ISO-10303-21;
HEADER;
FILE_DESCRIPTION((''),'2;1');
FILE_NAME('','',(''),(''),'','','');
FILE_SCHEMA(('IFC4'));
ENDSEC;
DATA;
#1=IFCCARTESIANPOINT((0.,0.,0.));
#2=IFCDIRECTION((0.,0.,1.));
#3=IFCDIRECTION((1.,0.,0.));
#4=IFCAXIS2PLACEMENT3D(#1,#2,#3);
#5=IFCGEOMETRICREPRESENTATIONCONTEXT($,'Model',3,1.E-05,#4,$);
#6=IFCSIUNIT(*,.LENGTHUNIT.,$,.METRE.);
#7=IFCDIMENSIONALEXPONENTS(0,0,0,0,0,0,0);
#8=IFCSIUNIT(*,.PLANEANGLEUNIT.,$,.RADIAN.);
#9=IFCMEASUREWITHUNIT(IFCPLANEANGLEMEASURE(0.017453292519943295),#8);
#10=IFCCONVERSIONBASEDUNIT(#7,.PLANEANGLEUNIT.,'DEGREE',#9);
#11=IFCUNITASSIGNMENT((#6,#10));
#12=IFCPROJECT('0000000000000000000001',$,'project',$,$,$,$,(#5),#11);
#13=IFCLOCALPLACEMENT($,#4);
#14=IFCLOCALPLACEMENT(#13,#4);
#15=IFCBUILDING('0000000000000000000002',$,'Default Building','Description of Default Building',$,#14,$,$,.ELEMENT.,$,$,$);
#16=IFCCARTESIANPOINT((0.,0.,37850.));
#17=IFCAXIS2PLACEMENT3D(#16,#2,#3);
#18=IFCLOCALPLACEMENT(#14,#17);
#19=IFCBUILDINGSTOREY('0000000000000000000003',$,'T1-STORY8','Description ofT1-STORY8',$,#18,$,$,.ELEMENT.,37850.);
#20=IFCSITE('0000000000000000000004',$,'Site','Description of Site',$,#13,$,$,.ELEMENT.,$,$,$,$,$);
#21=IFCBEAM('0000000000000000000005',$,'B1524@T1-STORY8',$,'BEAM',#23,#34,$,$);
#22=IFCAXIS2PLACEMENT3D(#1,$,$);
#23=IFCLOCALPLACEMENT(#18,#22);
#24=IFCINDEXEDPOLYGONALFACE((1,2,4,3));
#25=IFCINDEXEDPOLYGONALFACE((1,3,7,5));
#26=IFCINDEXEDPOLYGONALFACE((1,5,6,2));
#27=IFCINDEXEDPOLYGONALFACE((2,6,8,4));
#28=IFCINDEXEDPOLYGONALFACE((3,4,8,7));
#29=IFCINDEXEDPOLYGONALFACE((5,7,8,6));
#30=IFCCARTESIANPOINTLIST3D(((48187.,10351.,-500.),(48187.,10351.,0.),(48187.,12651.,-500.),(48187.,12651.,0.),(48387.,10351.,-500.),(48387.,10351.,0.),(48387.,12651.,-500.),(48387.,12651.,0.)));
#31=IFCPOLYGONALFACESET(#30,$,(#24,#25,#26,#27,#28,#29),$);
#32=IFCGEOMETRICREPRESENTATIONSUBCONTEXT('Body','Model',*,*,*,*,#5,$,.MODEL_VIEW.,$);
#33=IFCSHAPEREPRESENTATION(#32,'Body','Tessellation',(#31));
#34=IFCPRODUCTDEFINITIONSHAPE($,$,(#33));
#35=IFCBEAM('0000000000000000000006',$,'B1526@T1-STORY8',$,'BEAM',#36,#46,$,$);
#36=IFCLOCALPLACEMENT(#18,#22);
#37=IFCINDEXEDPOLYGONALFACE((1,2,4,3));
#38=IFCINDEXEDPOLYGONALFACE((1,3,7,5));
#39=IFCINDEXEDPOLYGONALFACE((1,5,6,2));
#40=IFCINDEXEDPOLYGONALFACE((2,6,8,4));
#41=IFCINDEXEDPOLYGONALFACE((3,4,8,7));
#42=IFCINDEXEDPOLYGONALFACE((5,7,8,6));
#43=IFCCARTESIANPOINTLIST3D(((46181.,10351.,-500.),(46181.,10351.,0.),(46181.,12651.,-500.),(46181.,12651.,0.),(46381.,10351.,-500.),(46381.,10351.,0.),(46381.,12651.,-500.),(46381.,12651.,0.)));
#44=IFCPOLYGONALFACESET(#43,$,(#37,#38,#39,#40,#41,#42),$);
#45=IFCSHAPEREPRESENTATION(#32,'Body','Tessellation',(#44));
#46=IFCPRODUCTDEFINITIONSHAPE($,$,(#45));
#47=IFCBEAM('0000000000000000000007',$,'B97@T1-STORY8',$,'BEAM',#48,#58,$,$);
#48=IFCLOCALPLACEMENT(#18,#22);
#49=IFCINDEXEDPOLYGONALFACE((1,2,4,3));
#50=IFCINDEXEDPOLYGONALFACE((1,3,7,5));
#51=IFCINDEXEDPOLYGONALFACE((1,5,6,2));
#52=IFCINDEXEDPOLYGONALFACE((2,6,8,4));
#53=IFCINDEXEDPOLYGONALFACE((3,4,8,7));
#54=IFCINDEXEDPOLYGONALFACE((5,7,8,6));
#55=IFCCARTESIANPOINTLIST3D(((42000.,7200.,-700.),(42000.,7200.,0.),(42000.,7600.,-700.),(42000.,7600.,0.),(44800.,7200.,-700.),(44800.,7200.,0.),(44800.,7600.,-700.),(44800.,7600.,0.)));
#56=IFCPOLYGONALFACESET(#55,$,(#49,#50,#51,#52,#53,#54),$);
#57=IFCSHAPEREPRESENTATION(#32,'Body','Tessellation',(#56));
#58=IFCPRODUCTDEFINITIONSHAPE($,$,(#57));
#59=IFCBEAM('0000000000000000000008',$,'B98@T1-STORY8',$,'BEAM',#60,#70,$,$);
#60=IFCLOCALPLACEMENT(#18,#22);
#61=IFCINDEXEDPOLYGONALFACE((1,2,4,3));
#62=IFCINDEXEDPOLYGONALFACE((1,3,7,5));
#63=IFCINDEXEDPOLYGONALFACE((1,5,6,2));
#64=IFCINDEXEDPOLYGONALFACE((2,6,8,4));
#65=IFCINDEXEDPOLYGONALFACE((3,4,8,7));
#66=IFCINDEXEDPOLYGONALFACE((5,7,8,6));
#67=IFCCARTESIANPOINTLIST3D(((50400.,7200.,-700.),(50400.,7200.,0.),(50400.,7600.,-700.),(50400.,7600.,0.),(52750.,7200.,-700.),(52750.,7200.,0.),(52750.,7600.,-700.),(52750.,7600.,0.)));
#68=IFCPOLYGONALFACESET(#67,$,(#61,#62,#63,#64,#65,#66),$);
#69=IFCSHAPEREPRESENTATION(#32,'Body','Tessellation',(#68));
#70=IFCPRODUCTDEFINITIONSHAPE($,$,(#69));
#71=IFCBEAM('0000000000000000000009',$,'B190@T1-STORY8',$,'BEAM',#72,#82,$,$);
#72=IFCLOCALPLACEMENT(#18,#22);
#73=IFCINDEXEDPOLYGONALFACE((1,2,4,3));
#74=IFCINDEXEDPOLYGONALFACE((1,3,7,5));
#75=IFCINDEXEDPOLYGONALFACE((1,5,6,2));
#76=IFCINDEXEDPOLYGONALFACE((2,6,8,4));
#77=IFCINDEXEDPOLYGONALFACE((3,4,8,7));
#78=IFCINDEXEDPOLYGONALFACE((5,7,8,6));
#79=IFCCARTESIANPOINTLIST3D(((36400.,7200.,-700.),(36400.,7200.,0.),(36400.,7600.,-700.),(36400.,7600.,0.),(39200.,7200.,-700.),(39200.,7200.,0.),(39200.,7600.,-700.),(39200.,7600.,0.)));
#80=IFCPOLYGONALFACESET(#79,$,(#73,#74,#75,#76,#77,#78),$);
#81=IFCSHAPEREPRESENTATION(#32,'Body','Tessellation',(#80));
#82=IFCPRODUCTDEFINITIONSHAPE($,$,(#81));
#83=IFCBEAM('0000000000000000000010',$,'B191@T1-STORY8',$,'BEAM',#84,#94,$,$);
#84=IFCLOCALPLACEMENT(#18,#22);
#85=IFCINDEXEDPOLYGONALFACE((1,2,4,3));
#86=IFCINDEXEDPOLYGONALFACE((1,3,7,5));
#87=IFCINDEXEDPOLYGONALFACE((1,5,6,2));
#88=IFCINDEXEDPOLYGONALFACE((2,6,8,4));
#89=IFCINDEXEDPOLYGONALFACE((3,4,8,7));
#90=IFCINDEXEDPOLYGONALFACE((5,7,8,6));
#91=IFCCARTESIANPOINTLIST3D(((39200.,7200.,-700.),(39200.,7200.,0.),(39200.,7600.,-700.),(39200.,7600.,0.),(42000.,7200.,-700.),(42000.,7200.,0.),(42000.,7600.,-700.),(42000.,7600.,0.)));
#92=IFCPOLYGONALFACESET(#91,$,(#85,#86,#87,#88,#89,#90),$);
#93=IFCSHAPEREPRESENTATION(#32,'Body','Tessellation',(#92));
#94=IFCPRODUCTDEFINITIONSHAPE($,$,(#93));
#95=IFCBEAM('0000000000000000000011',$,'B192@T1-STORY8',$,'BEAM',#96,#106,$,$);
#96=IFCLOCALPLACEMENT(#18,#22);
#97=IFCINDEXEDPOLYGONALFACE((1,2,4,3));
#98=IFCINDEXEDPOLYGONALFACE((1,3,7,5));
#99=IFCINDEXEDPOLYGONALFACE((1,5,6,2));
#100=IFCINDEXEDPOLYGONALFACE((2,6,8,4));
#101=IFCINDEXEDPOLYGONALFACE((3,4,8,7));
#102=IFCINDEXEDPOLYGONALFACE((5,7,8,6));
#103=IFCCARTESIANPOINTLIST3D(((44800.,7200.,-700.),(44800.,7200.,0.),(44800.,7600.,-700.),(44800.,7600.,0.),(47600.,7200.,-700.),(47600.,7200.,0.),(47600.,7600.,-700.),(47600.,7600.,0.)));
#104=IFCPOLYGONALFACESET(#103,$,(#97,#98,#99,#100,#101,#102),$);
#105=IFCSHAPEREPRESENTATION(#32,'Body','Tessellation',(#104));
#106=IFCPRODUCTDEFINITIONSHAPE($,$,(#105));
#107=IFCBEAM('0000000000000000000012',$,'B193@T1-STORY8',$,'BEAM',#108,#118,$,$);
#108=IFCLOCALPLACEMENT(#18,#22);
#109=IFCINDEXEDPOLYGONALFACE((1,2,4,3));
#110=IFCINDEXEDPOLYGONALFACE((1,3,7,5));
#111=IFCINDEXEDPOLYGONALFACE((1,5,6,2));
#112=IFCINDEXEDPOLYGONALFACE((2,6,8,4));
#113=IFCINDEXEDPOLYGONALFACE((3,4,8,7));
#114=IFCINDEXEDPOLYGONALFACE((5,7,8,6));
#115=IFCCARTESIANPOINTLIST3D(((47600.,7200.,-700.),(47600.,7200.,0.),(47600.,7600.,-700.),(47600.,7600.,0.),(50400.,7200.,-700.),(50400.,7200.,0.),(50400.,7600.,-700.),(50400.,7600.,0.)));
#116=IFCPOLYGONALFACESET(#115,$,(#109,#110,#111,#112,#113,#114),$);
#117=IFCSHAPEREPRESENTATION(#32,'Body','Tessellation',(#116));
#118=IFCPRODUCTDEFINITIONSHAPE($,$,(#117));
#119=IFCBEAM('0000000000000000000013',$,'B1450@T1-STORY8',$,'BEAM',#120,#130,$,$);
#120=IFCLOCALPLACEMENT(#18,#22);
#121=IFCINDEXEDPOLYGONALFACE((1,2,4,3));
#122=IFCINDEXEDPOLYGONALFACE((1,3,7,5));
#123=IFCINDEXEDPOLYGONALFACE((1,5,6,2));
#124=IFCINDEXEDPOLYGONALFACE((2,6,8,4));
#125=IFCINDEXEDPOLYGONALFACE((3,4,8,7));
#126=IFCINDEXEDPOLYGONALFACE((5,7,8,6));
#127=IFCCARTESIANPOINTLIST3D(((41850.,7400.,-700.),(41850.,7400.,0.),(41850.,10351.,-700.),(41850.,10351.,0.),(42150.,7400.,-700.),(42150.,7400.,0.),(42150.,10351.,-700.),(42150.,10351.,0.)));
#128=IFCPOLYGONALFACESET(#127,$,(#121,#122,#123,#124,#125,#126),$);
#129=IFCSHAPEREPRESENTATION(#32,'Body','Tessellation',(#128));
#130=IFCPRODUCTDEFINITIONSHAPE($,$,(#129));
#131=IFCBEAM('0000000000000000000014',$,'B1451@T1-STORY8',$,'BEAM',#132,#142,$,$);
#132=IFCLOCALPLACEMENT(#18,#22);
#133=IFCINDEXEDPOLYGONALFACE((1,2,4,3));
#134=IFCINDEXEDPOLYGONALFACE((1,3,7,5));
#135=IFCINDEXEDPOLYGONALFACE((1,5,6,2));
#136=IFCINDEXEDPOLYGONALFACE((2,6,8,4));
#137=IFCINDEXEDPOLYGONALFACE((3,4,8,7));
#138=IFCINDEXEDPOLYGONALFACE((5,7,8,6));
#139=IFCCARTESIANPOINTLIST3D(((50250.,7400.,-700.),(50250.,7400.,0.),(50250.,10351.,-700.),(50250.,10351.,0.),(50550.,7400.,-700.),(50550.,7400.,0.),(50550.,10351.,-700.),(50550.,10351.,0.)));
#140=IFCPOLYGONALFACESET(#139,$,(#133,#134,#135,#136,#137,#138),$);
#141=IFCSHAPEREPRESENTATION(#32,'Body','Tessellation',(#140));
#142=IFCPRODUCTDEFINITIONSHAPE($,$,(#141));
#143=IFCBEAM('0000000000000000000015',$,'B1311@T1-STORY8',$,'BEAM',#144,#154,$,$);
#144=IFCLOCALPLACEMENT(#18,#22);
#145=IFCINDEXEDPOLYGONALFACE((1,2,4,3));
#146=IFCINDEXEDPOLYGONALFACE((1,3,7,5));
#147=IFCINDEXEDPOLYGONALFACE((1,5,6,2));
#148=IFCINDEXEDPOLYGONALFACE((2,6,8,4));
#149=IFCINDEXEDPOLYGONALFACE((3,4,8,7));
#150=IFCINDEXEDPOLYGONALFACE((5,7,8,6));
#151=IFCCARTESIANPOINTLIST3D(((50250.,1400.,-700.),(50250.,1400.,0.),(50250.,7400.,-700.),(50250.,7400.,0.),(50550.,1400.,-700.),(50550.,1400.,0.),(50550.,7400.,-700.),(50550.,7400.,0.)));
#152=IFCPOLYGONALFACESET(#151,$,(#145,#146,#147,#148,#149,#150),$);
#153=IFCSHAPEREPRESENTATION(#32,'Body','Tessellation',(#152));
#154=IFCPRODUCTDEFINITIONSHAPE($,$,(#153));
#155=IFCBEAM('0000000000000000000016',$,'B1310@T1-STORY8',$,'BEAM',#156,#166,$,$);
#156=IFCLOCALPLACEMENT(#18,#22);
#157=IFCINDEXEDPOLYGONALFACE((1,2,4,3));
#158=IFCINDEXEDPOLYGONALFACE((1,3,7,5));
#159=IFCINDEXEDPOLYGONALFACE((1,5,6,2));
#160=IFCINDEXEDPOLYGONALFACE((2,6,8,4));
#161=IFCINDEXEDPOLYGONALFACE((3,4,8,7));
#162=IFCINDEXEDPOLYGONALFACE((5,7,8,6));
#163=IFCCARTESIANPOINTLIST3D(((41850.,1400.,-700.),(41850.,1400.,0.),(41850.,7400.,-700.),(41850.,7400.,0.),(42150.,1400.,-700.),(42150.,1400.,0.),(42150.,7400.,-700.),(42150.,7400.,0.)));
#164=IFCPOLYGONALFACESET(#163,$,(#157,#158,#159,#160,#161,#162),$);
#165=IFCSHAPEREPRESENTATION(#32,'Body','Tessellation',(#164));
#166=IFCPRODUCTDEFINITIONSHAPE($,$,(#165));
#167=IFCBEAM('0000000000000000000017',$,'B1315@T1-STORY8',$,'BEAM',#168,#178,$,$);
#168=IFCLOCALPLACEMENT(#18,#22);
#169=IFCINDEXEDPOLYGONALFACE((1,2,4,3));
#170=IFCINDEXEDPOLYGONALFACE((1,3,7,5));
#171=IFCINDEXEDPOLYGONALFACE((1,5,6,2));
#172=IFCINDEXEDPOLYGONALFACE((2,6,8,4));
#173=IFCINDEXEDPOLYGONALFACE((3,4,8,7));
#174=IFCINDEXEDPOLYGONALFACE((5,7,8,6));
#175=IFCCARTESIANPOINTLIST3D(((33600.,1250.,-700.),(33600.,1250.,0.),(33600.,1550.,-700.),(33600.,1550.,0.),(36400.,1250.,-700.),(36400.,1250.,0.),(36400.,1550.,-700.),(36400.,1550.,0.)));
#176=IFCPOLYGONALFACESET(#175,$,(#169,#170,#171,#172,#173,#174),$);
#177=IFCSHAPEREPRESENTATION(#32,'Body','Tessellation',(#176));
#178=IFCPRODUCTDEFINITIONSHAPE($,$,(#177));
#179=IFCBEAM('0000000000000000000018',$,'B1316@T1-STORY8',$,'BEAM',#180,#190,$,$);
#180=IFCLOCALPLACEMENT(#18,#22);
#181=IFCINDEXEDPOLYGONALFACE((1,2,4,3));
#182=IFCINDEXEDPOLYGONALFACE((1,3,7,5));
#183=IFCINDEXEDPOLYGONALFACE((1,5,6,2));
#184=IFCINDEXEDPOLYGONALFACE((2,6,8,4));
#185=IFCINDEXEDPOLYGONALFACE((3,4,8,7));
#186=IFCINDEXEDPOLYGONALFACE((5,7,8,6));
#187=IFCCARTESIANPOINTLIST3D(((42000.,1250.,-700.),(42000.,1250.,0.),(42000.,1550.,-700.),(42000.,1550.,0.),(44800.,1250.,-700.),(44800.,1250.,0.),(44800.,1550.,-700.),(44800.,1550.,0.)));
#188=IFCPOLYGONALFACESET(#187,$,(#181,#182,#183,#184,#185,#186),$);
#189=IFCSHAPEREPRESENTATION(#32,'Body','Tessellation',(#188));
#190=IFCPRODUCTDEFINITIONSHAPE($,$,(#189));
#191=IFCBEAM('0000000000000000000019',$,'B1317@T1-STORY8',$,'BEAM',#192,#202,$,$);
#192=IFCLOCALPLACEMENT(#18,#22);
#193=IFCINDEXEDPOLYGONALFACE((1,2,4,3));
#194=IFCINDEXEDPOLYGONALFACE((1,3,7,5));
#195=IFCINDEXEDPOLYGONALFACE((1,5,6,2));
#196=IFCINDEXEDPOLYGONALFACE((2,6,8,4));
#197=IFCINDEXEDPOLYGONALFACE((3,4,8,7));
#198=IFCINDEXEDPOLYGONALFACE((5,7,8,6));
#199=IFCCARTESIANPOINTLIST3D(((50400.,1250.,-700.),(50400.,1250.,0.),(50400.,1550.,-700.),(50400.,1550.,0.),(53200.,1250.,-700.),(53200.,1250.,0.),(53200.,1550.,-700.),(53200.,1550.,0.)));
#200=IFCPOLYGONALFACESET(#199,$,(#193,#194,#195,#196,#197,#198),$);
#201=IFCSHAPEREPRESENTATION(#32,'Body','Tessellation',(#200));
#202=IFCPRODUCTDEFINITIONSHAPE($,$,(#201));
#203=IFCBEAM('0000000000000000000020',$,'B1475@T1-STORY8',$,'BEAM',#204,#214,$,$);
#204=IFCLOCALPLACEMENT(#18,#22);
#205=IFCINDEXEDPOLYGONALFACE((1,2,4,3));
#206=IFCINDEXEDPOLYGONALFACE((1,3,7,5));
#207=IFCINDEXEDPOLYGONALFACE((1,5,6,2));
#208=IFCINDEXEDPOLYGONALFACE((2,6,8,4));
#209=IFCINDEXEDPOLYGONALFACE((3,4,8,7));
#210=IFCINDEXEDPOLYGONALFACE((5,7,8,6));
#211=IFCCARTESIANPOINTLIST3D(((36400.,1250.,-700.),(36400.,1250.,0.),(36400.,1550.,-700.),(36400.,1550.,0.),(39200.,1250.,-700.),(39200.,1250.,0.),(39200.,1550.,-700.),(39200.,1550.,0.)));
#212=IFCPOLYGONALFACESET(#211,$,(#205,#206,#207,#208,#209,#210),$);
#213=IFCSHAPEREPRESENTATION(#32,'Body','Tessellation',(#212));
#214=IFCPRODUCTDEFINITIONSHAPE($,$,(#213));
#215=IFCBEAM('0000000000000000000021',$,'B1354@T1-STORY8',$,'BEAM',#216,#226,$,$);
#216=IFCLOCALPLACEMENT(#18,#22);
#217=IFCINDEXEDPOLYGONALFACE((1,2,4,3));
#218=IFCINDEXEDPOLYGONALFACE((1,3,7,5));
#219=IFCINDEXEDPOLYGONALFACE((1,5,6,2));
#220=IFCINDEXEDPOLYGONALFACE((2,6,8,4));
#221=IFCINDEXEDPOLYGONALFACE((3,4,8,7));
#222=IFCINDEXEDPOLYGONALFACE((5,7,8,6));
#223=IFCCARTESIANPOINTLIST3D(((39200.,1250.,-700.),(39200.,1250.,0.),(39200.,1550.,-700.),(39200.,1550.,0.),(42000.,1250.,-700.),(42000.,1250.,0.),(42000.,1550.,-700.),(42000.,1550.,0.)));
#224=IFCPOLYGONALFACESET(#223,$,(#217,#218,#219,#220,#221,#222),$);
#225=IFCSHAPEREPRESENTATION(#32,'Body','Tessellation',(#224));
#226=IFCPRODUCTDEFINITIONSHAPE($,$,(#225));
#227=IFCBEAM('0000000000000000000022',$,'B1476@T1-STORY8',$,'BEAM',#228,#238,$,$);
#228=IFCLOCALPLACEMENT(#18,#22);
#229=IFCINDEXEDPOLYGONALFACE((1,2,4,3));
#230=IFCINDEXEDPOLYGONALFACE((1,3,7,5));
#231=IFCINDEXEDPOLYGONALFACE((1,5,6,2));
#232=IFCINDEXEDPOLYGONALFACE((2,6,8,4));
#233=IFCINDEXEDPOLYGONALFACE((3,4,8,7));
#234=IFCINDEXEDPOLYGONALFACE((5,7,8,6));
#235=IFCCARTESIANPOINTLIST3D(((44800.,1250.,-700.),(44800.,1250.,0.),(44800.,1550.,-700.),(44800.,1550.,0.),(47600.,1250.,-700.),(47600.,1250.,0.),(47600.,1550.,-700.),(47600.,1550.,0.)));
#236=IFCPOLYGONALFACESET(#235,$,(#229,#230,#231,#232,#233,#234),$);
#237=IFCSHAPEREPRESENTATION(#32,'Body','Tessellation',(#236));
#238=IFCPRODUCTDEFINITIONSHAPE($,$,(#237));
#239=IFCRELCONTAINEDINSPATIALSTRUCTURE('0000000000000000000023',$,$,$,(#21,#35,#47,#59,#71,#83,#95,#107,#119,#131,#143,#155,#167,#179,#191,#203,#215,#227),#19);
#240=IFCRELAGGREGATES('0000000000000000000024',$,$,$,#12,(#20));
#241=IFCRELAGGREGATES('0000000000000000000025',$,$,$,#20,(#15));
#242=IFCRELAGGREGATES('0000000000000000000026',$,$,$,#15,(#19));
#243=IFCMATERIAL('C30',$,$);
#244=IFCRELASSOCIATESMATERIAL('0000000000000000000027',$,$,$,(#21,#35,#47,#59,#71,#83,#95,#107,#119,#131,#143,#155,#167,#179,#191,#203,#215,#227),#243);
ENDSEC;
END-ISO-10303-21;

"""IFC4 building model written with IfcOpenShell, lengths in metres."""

from ifc_helpers import new_model, entity, si_unit, converted_unit, frame, origin_with_axes, place, context, subcontext, project, spatial, rectangle, extrude, material, element, save


model = new_model("IFC4")

# Units and contexts
model_context = context("Model", 3, precision=1e-05, world=origin_with_axes())
body_context = subcontext(model_context, "Body", "Model", "MODEL_VIEW")
ifc_project = project(units=[si_unit("LENGTHUNIT", "METRE"), converted_unit("PLANEANGLEUNIT", "DEGREE", entity("IfcPlaneAngleMeasure", 0.017453292519943295), si_unit("PLANEANGLEUNIT", "RADIAN"), dimensions=[0, 0, 0, 0, 0, 0, 0])], contexts=[model_context])

# Site, building, storey
site_placement = place(None, origin_with_axes())
site = spatial("IfcSite", under=ifc_project, at=site_placement, Name="Site", Description="Description of Site", CompositionType="ELEMENT")
building_placement = place(site_placement, origin_with_axes())
building = spatial("IfcBuilding", under=site, at=building_placement, Name="Default Building", Description="Description of Default Building", CompositionType="ELEMENT")
storey_placement = place(building_placement, frame((0.0, 0.0, 37850.0), z_axis=(0.0, 0.0, 1.0), x_axis=(1.0, 0.0, 0.0)))
storey = spatial("IfcBuildingStorey", under=building, at=storey_placement, Name="T1-STORY8", Description="Description ofT1-STORY8", CompositionType="ELEMENT", Elevation=37850.0)

# Beams
ifc_material_1 = material(Name="C30")
for number, where, z_axis, x_axis, name in (
    (1, (48287.0, 10351.0, -250.0), (0.0, 1.0, 0.0), (-1.0, 0.0, 0.0), "B1524@T1-STORY8"),
    (2, (46281.0, 10351.0, -250.0), (0.0, 1.0, 0.0), (-1.0, 0.0, 0.0), "B1526@T1-STORY8"),
):
    element("IfcBeam", number, at=place(storey_placement, frame(where, z_axis=z_axis, x_axis=x_axis)), inside=storey, material=ifc_material_1, Name=name, ObjectType="BEAM", context=body_context, shape_type="SweptSolid", body=[
        extrude(rectangle(XDim=200.0, YDim=500.0), origin_with_axes(), (0.0, 0.0, 1.0), 2300.0),
    ])
beam_1_placement = place(storey_placement, frame((42000.0, 7400.0, -350.0), z_axis=(1.0, 0.0, 0.0), x_axis=(0.0, 1.0, 0.0)))
element("IfcBeam", 3, at=beam_1_placement, inside=storey, material=ifc_material_1, Name="B97@T1-STORY8", ObjectType="BEAM", context=body_context, shape_type="SweptSolid", body=[
    extrude(rectangle(XDim=400.0, YDim=700.0), origin_with_axes(), (0.0, 0.0, 1.0), 2800.0),
])
beam_2_placement = place(storey_placement, frame((50400.0, 7400.0, -350.0), z_axis=(1.0, 0.0, 0.0), x_axis=(0.0, 1.0, 0.0)))
element("IfcBeam", 4, at=beam_2_placement, inside=storey, material=ifc_material_1, Name="B98@T1-STORY8", ObjectType="BEAM", context=body_context, shape_type="SweptSolid", body=[
    extrude(rectangle(XDim=400.0, YDim=700.0), origin_with_axes(), (0.0, 0.0, 1.0), 2350.0),
])
for number, where, z_axis, x_axis, name in (
    (5, (36400.0, 7400.0, -350.0), (1.0, 0.0, 0.0), (0.0, 1.0, 0.0), "B190@T1-STORY8"),
    (6, (39200.0, 7400.0, -350.0), (1.0, 0.0, 0.0), (0.0, 1.0, 0.0), "B191@T1-STORY8"),
    (7, (44800.0, 7400.0, -350.0), (1.0, 0.0, 0.0), (0.0, 1.0, 0.0), "B192@T1-STORY8"),
    (8, (47600.0, 7400.0, -350.0), (1.0, 0.0, 0.0), (0.0, 1.0, 0.0), "B193@T1-STORY8"),
):
    element("IfcBeam", number, at=place(storey_placement, frame(where, z_axis=z_axis, x_axis=x_axis)), inside=storey, material=ifc_material_1, Name=name, ObjectType="BEAM", context=body_context, shape_type="SweptSolid", body=[
        extrude(rectangle(XDim=400.0, YDim=700.0), origin_with_axes(), (0.0, 0.0, 1.0), 2800.0),
    ])
for number, where, z_axis, x_axis, name in (
    (9, (42000.0, 7400.0, -350.0), (0.0, 1.0, 0.0), (-1.0, 0.0, 0.0), "B1450@T1-STORY8"),
    (10, (50400.0, 7400.0, -350.0), (0.0, 1.0, 0.0), (-1.0, 0.0, 0.0), "B1451@T1-STORY8"),
):
    element("IfcBeam", number, at=place(storey_placement, frame(where, z_axis=z_axis, x_axis=x_axis)), inside=storey, material=ifc_material_1, Name=name, ObjectType="BEAM", context=body_context, shape_type="SweptSolid", body=[
        extrude(rectangle(XDim=300.0, YDim=700.0), origin_with_axes(), (0.0, 0.0, 1.0), 2951.0),
    ])
for number, where, z_axis, x_axis, name in (
    (11, (50400.0, 1400.0, -350.0), (0.0, 1.0, 0.0), (-1.0, 0.0, 0.0), "B1311@T1-STORY8"),
    (12, (42000.0, 1400.0, -350.0), (0.0, 1.0, 0.0), (-1.0, 0.0, 0.0), "B1310@T1-STORY8"),
):
    element("IfcBeam", number, at=place(storey_placement, frame(where, z_axis=z_axis, x_axis=x_axis)), inside=storey, material=ifc_material_1, Name=name, ObjectType="BEAM", context=body_context, shape_type="SweptSolid", body=[
        extrude(rectangle(XDim=300.0, YDim=700.0), origin_with_axes(), (0.0, 0.0, 1.0), 6000.0),
    ])
for number, where, z_axis, x_axis, name in (
    (13, (33600.0, 1400.0, -350.0), (1.0, 0.0, 0.0), (0.0, 1.0, 0.0), "B1315@T1-STORY8"),
    (14, (42000.0, 1400.0, -350.0), (1.0, 0.0, 0.0), (0.0, 1.0, 0.0), "B1316@T1-STORY8"),
    (15, (50400.0, 1400.0, -350.0), (1.0, 0.0, 0.0), (0.0, 1.0, 0.0), "B1317@T1-STORY8"),
    (16, (36400.0, 1400.0, -350.0), (1.0, 0.0, 0.0), (0.0, 1.0, 0.0), "B1475@T1-STORY8"),
    (17, (39200.0, 1400.0, -350.0), (1.0, 0.0, 0.0), (0.0, 1.0, 0.0), "B1354@T1-STORY8"),
    (18, (44800.0, 1400.0, -350.0), (1.0, 0.0, 0.0), (0.0, 1.0, 0.0), "B1476@T1-STORY8"),
):
    element("IfcBeam", number, at=place(storey_placement, frame(where, z_axis=z_axis, x_axis=x_axis)), inside=storey, material=ifc_material_1, Name=name, ObjectType="BEAM", context=body_context, shape_type="SweptSolid", body=[
        extrude(rectangle(XDim=300.0, YDim=700.0), origin_with_axes(), (0.0, 0.0, 1.0), 2800.0),
    ])

save(model, "model.ifc")
